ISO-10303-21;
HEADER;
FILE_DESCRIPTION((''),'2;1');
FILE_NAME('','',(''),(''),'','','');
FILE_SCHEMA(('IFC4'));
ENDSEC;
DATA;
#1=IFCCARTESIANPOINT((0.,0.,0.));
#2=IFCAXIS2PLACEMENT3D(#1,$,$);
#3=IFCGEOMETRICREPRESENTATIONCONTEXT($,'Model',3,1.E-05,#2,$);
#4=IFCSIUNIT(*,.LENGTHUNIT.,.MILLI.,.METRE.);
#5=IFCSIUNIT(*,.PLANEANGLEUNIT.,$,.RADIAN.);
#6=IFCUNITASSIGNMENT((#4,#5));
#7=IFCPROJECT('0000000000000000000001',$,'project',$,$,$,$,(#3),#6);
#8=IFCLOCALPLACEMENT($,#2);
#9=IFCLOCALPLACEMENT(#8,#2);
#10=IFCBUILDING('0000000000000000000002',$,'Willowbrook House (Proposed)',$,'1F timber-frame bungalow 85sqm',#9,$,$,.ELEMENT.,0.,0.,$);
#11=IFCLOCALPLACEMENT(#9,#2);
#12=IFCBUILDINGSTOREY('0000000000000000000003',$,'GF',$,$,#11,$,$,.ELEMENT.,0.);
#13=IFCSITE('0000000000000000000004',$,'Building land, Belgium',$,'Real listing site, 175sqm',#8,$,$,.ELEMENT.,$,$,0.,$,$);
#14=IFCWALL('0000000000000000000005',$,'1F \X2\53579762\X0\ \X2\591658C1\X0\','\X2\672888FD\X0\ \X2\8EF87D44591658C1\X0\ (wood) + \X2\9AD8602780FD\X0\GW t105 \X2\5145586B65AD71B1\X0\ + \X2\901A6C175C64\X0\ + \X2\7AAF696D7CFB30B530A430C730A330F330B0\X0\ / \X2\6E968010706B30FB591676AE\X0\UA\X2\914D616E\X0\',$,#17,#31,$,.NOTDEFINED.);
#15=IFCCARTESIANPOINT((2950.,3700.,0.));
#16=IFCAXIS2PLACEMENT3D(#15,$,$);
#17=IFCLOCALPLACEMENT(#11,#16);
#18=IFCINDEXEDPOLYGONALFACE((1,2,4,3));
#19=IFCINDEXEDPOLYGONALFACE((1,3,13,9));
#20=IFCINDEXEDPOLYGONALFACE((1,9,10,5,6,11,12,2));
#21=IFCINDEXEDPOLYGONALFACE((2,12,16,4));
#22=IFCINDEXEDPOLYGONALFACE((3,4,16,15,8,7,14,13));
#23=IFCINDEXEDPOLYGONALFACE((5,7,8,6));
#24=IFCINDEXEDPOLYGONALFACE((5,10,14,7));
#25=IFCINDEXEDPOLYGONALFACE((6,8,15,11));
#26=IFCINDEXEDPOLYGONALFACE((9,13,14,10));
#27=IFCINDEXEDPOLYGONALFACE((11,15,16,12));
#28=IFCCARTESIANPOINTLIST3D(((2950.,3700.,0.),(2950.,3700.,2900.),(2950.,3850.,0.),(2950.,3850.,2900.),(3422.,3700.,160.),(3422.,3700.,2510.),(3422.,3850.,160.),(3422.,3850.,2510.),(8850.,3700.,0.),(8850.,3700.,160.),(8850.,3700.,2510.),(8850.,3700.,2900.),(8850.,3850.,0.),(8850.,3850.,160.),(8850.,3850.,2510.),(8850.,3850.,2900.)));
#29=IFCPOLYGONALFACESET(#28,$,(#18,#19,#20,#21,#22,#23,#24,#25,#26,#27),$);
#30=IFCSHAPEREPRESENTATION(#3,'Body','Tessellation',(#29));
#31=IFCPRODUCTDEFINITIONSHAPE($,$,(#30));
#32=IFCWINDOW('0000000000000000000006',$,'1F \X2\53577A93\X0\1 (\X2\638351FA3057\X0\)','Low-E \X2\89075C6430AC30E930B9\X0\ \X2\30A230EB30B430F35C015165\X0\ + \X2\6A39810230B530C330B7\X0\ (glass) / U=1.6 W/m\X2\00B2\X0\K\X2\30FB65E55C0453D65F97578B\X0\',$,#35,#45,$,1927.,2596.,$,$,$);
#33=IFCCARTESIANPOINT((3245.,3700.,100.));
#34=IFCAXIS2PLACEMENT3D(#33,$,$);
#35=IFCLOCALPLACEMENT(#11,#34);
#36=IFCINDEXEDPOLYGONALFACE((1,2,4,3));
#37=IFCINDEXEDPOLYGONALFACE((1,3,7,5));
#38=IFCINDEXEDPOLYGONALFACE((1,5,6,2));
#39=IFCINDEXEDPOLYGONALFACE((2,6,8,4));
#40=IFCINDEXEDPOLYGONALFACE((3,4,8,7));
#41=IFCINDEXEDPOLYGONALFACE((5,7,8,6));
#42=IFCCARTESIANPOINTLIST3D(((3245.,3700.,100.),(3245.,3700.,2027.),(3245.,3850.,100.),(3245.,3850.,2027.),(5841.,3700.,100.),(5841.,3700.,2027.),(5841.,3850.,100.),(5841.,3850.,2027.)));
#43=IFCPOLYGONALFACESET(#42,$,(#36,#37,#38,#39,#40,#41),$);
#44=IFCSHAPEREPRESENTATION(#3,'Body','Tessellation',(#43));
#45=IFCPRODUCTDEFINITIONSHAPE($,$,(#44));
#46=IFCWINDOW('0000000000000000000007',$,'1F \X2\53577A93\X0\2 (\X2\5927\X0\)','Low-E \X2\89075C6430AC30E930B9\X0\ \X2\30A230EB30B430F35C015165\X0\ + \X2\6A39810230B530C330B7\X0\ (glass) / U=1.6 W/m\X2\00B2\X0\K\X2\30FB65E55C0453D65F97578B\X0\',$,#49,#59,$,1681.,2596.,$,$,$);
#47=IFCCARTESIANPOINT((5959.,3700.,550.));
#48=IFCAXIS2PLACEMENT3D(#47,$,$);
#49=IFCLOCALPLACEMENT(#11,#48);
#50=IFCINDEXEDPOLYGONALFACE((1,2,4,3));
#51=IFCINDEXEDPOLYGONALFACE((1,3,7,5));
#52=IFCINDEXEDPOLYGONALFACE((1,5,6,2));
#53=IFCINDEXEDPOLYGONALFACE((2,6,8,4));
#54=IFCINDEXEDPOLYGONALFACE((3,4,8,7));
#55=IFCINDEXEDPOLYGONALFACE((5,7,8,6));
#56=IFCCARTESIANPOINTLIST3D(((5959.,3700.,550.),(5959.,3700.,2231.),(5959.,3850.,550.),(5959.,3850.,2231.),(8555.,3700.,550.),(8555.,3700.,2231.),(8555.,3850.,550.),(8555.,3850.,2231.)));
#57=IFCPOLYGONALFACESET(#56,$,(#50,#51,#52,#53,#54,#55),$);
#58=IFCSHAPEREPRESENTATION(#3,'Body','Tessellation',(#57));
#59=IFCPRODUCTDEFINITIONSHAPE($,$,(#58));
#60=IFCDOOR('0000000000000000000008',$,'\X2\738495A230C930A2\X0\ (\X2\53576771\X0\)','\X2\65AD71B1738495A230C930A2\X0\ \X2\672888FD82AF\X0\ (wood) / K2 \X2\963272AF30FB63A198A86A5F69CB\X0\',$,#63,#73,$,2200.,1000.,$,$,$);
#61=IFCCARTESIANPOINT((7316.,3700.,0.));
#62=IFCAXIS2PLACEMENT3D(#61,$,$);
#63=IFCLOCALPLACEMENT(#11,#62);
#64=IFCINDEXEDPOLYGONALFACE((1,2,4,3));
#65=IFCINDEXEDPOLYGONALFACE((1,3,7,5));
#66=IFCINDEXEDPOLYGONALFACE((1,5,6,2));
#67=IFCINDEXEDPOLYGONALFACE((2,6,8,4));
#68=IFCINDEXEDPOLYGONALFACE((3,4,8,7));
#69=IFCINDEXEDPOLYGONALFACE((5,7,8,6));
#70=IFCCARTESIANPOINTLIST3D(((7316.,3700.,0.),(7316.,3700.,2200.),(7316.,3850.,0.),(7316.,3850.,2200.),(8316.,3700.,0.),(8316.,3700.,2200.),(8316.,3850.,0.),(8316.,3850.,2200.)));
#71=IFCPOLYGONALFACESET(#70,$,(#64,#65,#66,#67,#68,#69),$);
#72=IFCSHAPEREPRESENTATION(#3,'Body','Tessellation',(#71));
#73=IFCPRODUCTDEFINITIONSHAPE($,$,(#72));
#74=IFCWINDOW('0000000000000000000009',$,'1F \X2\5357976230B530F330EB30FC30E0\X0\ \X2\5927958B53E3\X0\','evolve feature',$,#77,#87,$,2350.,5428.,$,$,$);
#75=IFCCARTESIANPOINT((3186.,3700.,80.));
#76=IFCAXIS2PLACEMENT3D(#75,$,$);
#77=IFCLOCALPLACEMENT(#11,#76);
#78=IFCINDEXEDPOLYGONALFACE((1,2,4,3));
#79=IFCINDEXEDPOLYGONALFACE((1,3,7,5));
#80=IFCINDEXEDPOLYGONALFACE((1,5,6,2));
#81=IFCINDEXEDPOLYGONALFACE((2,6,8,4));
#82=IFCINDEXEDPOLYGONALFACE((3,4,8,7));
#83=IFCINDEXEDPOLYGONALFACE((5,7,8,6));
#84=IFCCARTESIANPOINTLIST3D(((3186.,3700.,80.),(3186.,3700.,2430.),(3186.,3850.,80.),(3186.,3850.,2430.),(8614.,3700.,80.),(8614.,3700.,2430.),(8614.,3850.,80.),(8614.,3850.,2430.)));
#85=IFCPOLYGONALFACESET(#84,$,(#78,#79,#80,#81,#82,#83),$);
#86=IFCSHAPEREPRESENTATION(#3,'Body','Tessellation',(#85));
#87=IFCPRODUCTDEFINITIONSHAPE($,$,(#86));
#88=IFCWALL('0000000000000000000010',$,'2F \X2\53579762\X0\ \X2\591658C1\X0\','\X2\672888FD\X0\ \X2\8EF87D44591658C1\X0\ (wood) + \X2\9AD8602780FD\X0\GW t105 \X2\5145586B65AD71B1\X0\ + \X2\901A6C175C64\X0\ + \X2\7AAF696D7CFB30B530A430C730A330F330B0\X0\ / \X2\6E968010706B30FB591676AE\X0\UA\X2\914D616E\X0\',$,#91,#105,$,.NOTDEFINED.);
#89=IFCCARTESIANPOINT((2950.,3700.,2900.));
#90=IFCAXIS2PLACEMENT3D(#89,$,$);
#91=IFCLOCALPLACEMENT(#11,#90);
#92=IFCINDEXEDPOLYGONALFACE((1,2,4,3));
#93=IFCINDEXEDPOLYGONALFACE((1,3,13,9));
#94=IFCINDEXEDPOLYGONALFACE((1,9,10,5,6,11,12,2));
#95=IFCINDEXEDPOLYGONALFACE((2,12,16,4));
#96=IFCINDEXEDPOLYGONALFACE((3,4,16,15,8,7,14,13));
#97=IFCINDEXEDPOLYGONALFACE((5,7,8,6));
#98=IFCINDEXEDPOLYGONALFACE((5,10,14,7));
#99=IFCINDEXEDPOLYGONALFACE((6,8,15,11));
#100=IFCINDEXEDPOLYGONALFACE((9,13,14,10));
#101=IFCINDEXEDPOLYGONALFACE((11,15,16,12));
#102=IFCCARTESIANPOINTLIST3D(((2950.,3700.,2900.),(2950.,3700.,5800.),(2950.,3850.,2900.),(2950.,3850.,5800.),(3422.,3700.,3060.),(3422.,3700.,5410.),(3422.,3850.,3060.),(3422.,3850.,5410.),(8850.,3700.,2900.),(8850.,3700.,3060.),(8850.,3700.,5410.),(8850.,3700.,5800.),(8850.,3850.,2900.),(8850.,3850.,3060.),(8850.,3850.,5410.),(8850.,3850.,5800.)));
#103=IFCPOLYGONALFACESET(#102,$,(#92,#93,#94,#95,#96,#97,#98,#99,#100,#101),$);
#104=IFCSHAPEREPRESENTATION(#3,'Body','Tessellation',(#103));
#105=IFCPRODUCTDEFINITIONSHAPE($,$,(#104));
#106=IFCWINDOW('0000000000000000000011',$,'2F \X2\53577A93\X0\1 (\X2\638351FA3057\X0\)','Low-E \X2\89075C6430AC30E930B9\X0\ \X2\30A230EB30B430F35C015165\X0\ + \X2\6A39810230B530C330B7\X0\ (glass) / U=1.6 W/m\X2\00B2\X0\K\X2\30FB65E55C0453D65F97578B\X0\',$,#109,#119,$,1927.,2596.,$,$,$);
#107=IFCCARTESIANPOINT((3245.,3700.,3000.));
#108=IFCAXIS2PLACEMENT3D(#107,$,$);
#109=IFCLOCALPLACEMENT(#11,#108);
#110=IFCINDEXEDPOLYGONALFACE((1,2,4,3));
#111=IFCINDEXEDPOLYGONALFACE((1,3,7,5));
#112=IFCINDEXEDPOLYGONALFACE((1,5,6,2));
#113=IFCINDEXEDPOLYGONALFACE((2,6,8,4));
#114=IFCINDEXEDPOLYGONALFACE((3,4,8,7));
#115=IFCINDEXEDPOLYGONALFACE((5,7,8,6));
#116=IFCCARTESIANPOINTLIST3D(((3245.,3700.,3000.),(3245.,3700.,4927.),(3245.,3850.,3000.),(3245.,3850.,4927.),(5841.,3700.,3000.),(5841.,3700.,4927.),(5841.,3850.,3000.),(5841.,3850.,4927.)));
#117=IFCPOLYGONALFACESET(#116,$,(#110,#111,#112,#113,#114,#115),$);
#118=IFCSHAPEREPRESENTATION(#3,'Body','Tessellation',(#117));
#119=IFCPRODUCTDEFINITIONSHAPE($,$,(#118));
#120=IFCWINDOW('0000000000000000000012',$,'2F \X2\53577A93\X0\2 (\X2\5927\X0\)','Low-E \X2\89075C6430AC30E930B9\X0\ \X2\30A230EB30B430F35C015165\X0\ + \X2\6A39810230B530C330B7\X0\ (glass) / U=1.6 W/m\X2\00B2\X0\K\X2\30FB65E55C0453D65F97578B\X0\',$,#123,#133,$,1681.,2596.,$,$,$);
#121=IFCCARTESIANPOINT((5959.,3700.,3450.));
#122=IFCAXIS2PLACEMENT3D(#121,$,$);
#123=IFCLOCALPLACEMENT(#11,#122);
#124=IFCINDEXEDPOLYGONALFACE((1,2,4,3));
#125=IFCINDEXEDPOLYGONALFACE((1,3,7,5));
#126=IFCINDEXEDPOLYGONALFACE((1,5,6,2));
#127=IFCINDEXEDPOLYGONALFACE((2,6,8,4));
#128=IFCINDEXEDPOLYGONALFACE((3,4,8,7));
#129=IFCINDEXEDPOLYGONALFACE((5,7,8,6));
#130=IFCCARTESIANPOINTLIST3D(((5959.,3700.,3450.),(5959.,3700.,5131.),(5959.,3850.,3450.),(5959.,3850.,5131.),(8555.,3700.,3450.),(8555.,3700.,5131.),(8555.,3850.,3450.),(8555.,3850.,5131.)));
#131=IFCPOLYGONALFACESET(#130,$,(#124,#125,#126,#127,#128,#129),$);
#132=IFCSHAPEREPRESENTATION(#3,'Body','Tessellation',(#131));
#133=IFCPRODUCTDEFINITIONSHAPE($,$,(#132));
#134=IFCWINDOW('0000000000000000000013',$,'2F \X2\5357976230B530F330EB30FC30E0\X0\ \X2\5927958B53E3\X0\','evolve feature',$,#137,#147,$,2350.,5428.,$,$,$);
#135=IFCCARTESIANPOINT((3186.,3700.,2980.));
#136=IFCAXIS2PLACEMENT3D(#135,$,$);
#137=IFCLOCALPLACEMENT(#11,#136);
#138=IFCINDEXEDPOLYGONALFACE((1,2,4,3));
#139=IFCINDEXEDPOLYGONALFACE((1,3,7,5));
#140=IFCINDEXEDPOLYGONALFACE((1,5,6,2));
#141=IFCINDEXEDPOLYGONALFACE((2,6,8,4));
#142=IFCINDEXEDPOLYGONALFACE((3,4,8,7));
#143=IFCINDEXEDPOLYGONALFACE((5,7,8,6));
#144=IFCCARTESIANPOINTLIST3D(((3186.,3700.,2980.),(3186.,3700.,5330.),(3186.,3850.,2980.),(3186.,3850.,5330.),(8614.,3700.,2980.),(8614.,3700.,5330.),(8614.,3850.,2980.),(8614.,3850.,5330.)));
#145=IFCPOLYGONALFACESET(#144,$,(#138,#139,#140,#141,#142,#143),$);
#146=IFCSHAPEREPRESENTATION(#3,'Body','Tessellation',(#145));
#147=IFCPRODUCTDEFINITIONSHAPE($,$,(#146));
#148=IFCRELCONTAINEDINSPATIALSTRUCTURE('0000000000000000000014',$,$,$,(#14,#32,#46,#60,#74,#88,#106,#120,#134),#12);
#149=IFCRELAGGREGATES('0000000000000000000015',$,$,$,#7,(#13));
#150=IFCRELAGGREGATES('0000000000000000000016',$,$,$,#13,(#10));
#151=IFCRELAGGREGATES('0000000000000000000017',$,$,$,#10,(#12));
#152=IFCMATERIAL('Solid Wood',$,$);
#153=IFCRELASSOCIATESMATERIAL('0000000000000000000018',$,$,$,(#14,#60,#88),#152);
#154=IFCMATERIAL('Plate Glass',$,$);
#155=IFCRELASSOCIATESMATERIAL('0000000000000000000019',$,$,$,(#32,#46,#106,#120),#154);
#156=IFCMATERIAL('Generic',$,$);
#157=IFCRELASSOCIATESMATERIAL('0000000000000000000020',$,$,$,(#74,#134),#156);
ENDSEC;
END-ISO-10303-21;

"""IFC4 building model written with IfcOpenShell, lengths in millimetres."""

from ifc_helpers import new_model, si_unit, frame, frame_2d, origin, place, context, project, spatial, rectangle, extrude, material, element, fill, save


model = new_model("IFC4")

# Units and contexts
model_context = context("Model", 3, precision=1e-05, world=origin())
ifc_project = project(units=[si_unit("LENGTHUNIT", "METRE", prefix="MILLI"), si_unit("PLANEANGLEUNIT", "RADIAN")], contexts=[model_context])

# Site, building, storey
site_placement = place(None, origin())
site = spatial("IfcSite", under=ifc_project, at=site_placement, Name="Building land, Belgium", ObjectType="Real listing site, 175sqm", CompositionType="ELEMENT", RefElevation=0.0)
building_placement = place(site_placement, origin())
building = spatial("IfcBuilding", under=site, at=building_placement, Name="Willowbrook House (Proposed)", ObjectType="1F timber-frame bungalow 85sqm", CompositionType="ELEMENT", ElevationOfRefHeight=0.0, ElevationOfTerrain=0.0)
storey_placement = place(building_placement, origin())
storey = spatial("IfcBuildingStorey", under=building, at=storey_placement, Name="GF", CompositionType="ELEMENT", Elevation=0.0)

# Shared definitions
ifc_material_1 = material(Name="Solid Wood")
ifc_material_2 = material(Name="Generic")

# Wall, openings, windows, door
wall_1_placement = place(storey_placement, frame((2950.0, 3700.0, 0.0)))
wall_1 = element("IfcWall", 1, at=wall_1_placement, inside=storey, material=ifc_material_1, Name="1F 南面 外壁", Description="木製 軸組外壁 (wood) + 高性能GW t105 充填断熱 + 通気層 + 窯業系サイディング / 準耐火・外皮UA配慮", PredefinedType="NOTDEFINED", context=model_context, shape_type="SweptSolid", body=[
    extrude(rectangle(XDim=5900.0, YDim=150.0, at=frame_2d((2950.0, 75.0))), frame((2950.0, 3700.0, 0.0)), (0.0, 0.0, 1.0), 2900.0),
])
opening_1_placement = place(storey_placement, frame((3245.0, 3700.0, 100.0)))
opening_1 = element("IfcOpeningElement", 2, at=opening_1_placement, cuts=wall_1, PredefinedType="NOTDEFINED", context=model_context, shape_type="SweptSolid", body=[
    extrude(rectangle(XDim=2596.0, YDim=150.0, at=frame_2d((1298.0, 75.0))), frame((3245.0, 3700.0, 100.0)), (0.0, 0.0, 1.0), 1927.0),
])
opening_2_placement = place(storey_placement, frame((5959.0, 3700.0, 550.0)))
opening_2 = element("IfcOpeningElement", 3, at=opening_2_placement, cuts=wall_1, PredefinedType="NOTDEFINED", context=model_context, shape_type="SweptSolid", body=[
    extrude(rectangle(XDim=2596.0, YDim=150.0, at=frame_2d((1298.0, 75.0))), frame((5959.0, 3700.0, 550.0)), (0.0, 0.0, 1.0), 1681.0),
])
opening_3_placement = place(storey_placement, frame((7316.0, 3700.0, 0.0)))
opening_3 = element("IfcOpeningElement", 4, at=opening_3_placement, cuts=wall_1, PredefinedType="NOTDEFINED", context=model_context, shape_type="SweptSolid", body=[
    extrude(rectangle(XDim=1000.0, YDim=150.0, at=frame_2d((500.0, 75.0))), frame((7316.0, 3700.0, 0.0)), (0.0, 0.0, 1.0), 2200.0),
])
opening_4_placement = place(storey_placement, frame((3186.0, 3700.0, 80.0)))
opening_4 = element("IfcOpeningElement", 5, at=opening_4_placement, cuts=wall_1, PredefinedType="NOTDEFINED", context=model_context, shape_type="SweptSolid", body=[
    extrude(rectangle(XDim=5428.0, YDim=150.0, at=frame_2d((2714.0, 75.0))), frame((3186.0, 3700.0, 80.0)), (0.0, 0.0, 1.0), 2350.0),
])
ifc_material_3 = material(Name="Plate Glass")
window_1_placement = place(storey_placement, frame((3245.0, 3700.0, 100.0)))
window_1 = element("IfcWindow", 6, at=window_1_placement, inside=storey, material=ifc_material_3, Name="1F 南窓1 (掃出し)", Description="Low-E 複層ガラス アルゴン封入 + 樹脂サッシ (glass) / U=1.6 W/m²K・日射取得型", OverallHeight=1927.0, OverallWidth=2596.0, context=model_context, shape_type="SweptSolid", body=[
    extrude(rectangle(XDim=2596.0, YDim=150.0, at=frame_2d((1298.0, 75.0))), frame((3245.0, 3700.0, 100.0)), (0.0, 0.0, 1.0), 1927.0),
])
fill(opening_1, window_1)
window_2_placement = place(storey_placement, frame((5959.0, 3700.0, 550.0)))
window_2 = element("IfcWindow", 7, at=window_2_placement, inside=storey, material=ifc_material_3, Name="1F 南窓2 (大)", Description="Low-E 複層ガラス アルゴン封入 + 樹脂サッシ (glass) / U=1.6 W/m²K・日射取得型", OverallHeight=1681.0, OverallWidth=2596.0, context=model_context, shape_type="SweptSolid", body=[
    extrude(rectangle(XDim=2596.0, YDim=150.0, at=frame_2d((1298.0, 75.0))), frame((5959.0, 3700.0, 550.0)), (0.0, 0.0, 1.0), 1681.0),
])
fill(opening_2, window_2)
door_placement = place(storey_placement, frame((7316.0, 3700.0, 0.0)))
door = element("IfcDoor", 8, at=door_placement, inside=storey, material=ifc_material_1, Name="玄関ドア (南東)", Description="断熱玄関ドア 木製芯 (wood) / K2 防犯・採風機構", OverallHeight=2200.0, OverallWidth=1000.0, context=model_context, shape_type="SweptSolid", body=[
    extrude(rectangle(XDim=1000.0, YDim=150.0, at=frame_2d((500.0, 75.0))), frame((7316.0, 3700.0, 0.0)), (0.0, 0.0, 1.0), 2200.0),
])
fill(opening_3, door)
window_3_placement = place(storey_placement, frame((3186.0, 3700.0, 80.0)))
window_3 = element("IfcWindow", 9, at=window_3_placement, inside=storey, material=ifc_material_2, Name="1F 南面サンルーム 大開口", Description="evolve feature", OverallHeight=2350.0, OverallWidth=5428.0, context=model_context, shape_type="SweptSolid", body=[
    extrude(rectangle(XDim=5428.0, YDim=150.0, at=frame_2d((2714.0, 75.0))), frame((3186.0, 3700.0, 80.0)), (0.0, 0.0, 1.0), 2350.0),
])
fill(opening_4, window_3)

# Wall, openings, windows
wall_2_placement = place(storey_placement, frame((2950.0, 3700.0, 2900.0)))
wall_2 = element("IfcWall", 10, at=wall_2_placement, inside=storey, material=ifc_material_1, Name="2F 南面 外壁", Description="木製 軸組外壁 (wood) + 高性能GW t105 充填断熱 + 通気層 + 窯業系サイディング / 準耐火・外皮UA配慮", PredefinedType="NOTDEFINED", context=model_context, shape_type="SweptSolid", body=[
    extrude(rectangle(XDim=5900.0, YDim=150.0, at=frame_2d((2950.0, 75.0))), frame((2950.0, 3700.0, 2900.0)), (0.0, 0.0, 1.0), 2900.0),
])
opening_5_placement = place(storey_placement, frame((3245.0, 3700.0, 3000.0)))
opening_5 = element("IfcOpeningElement", 11, at=opening_5_placement, cuts=wall_2, PredefinedType="NOTDEFINED", context=model_context, shape_type="SweptSolid", body=[
    extrude(rectangle(XDim=2596.0, YDim=150.0, at=frame_2d((1298.0, 75.0))), frame((3245.0, 3700.0, 3000.0)), (0.0, 0.0, 1.0), 1927.0),
])
opening_6_placement = place(storey_placement, frame((5959.0, 3700.0, 3450.0)))
opening_6 = element("IfcOpeningElement", 12, at=opening_6_placement, cuts=wall_2, PredefinedType="NOTDEFINED", context=model_context, shape_type="SweptSolid", body=[
    extrude(rectangle(XDim=2596.0, YDim=150.0, at=frame_2d((1298.0, 75.0))), frame((5959.0, 3700.0, 3450.0)), (0.0, 0.0, 1.0), 1681.0),
])
opening_7_placement = place(storey_placement, frame((3186.0, 3700.0, 2980.0)))
opening_7 = element("IfcOpeningElement", 13, at=opening_7_placement, cuts=wall_2, PredefinedType="NOTDEFINED", context=model_context, shape_type="SweptSolid", body=[
    extrude(rectangle(XDim=5428.0, YDim=150.0, at=frame_2d((2714.0, 75.0))), frame((3186.0, 3700.0, 2980.0)), (0.0, 0.0, 1.0), 2350.0),
])
window_4_placement = place(storey_placement, frame((3245.0, 3700.0, 3000.0)))
window_4 = element("IfcWindow", 14, at=window_4_placement, inside=storey, material=ifc_material_3, Name="2F 南窓1 (掃出し)", Description="Low-E 複層ガラス アルゴン封入 + 樹脂サッシ (glass) / U=1.6 W/m²K・日射取得型", OverallHeight=1927.0, OverallWidth=2596.0, context=model_context, shape_type="SweptSolid", body=[
    extrude(rectangle(XDim=2596.0, YDim=150.0, at=frame_2d((1298.0, 75.0))), frame((3245.0, 3700.0, 3000.0)), (0.0, 0.0, 1.0), 1927.0),
])
fill(opening_5, window_4)
window_5_placement = place(storey_placement, frame((5959.0, 3700.0, 3450.0)))
window_5 = element("IfcWindow", 15, at=window_5_placement, inside=storey, material=ifc_material_3, Name="2F 南窓2 (大)", Description="Low-E 複層ガラス アルゴン封入 + 樹脂サッシ (glass) / U=1.6 W/m²K・日射取得型", OverallHeight=1681.0, OverallWidth=2596.0, context=model_context, shape_type="SweptSolid", body=[
    extrude(rectangle(XDim=2596.0, YDim=150.0, at=frame_2d((1298.0, 75.0))), frame((5959.0, 3700.0, 3450.0)), (0.0, 0.0, 1.0), 1681.0),
])
fill(opening_6, window_5)
window_6_placement = place(storey_placement, frame((3186.0, 3700.0, 2980.0)))
window_6 = element("IfcWindow", 16, at=window_6_placement, inside=storey, material=ifc_material_2, Name="2F 南面サンルーム 大開口", Description="evolve feature", OverallHeight=2350.0, OverallWidth=5428.0, context=model_context, shape_type="SweptSolid", body=[
    extrude(rectangle(XDim=5428.0, YDim=150.0, at=frame_2d((2714.0, 75.0))), frame((3186.0, 3700.0, 2980.0)), (0.0, 0.0, 1.0), 2350.0),
])
fill(opening_7, window_6)

save(model, "model.ifc")
